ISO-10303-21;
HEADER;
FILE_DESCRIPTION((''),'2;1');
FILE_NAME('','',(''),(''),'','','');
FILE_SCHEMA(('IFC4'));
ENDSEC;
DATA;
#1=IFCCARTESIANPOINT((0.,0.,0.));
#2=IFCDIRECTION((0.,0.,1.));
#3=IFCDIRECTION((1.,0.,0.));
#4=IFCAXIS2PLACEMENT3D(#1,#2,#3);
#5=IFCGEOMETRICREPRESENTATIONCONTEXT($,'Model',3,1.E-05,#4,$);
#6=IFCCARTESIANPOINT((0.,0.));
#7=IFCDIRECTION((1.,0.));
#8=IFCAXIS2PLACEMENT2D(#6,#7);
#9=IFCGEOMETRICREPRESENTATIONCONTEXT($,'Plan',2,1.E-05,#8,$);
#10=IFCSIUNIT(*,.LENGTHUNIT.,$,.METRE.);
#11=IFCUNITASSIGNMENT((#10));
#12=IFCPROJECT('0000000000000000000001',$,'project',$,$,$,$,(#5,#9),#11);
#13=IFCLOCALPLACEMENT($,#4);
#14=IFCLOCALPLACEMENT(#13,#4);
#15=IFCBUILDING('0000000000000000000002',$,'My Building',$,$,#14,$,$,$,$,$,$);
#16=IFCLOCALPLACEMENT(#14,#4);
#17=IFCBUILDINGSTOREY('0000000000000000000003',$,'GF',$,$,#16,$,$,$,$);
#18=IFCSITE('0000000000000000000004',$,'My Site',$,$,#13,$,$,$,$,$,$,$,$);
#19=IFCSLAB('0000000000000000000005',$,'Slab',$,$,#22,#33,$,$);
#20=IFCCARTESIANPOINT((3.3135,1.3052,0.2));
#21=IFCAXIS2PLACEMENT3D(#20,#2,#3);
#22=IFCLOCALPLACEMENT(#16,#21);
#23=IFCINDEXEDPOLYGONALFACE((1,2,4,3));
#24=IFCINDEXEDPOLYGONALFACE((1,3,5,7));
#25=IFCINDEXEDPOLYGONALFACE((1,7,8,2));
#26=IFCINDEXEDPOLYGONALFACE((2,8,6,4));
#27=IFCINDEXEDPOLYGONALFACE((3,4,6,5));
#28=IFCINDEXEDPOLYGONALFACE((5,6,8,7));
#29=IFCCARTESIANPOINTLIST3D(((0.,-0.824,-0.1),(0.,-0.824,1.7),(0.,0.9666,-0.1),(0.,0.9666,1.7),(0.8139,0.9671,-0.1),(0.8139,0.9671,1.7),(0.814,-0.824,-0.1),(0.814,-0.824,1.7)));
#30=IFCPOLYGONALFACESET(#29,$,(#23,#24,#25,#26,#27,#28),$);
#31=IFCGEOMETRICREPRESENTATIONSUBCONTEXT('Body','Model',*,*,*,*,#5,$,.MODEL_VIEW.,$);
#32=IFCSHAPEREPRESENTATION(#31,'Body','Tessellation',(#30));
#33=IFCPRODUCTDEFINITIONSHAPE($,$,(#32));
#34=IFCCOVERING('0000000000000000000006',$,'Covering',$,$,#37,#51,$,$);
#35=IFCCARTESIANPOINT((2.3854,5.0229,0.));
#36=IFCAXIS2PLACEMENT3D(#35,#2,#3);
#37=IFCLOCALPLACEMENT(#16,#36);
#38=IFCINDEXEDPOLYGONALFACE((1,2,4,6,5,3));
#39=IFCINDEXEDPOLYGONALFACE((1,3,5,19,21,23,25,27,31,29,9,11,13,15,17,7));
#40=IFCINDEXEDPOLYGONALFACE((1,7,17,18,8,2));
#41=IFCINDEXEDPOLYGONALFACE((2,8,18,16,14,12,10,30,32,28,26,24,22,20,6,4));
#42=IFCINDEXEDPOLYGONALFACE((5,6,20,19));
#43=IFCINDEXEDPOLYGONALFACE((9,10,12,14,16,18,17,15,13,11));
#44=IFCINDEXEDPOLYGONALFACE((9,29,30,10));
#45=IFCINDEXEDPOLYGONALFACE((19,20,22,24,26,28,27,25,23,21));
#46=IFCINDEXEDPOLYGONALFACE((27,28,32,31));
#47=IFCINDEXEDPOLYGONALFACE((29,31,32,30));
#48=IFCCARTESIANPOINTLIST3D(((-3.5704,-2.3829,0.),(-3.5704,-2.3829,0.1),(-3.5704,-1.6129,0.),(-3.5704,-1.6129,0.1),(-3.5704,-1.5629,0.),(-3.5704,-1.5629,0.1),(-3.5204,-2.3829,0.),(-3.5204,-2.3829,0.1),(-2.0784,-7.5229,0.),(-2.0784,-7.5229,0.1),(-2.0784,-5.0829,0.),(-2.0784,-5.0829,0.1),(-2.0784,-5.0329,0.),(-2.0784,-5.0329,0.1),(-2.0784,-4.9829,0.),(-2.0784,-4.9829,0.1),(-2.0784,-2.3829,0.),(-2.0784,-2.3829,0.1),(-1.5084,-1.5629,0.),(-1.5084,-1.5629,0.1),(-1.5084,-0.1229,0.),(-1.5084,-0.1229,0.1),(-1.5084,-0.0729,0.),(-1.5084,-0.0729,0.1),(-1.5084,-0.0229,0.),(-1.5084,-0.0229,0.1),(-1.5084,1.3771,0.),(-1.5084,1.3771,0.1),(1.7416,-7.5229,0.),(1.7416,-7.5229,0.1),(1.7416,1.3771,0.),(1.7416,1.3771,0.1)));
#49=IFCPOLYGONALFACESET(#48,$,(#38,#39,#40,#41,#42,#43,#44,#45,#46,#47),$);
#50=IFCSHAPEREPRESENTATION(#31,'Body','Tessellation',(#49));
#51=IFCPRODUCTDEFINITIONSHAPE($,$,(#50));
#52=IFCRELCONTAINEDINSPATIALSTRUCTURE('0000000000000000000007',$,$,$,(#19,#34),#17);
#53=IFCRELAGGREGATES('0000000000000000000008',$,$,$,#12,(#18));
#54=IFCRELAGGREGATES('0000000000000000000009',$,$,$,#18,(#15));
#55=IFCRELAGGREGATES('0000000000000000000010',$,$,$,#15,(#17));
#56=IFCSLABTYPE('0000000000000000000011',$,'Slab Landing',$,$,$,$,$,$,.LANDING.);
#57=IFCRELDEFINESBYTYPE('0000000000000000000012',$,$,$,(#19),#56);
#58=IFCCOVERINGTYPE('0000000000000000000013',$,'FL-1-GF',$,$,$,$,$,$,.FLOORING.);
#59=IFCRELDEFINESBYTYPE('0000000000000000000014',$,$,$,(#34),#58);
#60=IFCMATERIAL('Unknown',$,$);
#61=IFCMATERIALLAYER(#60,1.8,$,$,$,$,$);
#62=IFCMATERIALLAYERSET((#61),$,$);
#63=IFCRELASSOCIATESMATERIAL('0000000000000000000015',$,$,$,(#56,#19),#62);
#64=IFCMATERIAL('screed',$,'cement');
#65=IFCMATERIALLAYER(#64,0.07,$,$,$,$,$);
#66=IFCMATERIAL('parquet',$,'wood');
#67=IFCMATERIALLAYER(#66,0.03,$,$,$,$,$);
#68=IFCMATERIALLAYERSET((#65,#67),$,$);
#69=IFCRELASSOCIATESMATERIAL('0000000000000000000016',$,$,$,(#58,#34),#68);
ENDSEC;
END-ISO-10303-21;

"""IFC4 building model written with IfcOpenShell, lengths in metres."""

from ifc_helpers import new_model, si_unit, frame, origin_with_axes, origin_2d_with_axis, place, context, subcontext, project, spatial, line, indexed_curve, outline, extrude, material, layer, layer_set, layer_usage, type_object, element, save


model = new_model("IFC4")

# Units and contexts
model_context = context("Model", 3, precision=1e-05, world=origin_with_axes())
plan_context = context("Plan", 2, precision=1e-05, world=origin_2d_with_axis())
body_context_1 = subcontext(model_context, "Body", "Model", "MODEL_VIEW")
ifc_project = project(units=[si_unit("LENGTHUNIT", "METRE")], contexts=[model_context, plan_context])

# Site, building, storey
site_placement = place(None, origin_with_axes())
site = spatial("IfcSite", under=ifc_project, at=site_placement, Name="My Site")
building_placement = place(site_placement, origin_with_axes())
building = spatial("IfcBuilding", under=site, at=building_placement, Name="My Building")
storey_placement = place(building_placement, origin_with_axes())
storey = spatial("IfcBuildingStorey", under=building, at=storey_placement, Name="GF")

# Slab
ifc_material_1 = material(Name="Unknown")
ifc_layer_1 = layer(ifc_material_1, 1.8)
ifc_layer_set_1 = layer_set([ifc_layer_1])
ifc_layer_usage_1 = layer_usage(ifc_layer_set_1, "AXIS3", "POSITIVE", -0.1)
slab_type_1 = type_object("IfcSlabType", Name="Slab Landing", PredefinedType="LANDING", material=ifc_layer_set_1)
slab_1_placement = place(storey_placement, frame((3.3135, 1.3052, 0.2), z_axis=(0.0, 0.0, 1.0), x_axis=(1.0, 0.0, 0.0)))
element("IfcSlab", 1, at=slab_1_placement, inside=storey, type_object=slab_type_1, material=ifc_layer_usage_1, Name="Slab", context=body_context_1, shape_type="SweptSolid", body=[
    extrude(outline(indexed_curve([(0.0, 0.9666), (0.0, -0.824), (0.814, -0.824), (0.8139, 0.9671), (0.0, 0.9666)])), frame((0.0, 0.0, -0.1), z_axis=(0.0, 0.0, 1.0), x_axis=(1.0, 0.0, 0.0)), (0.0, 0.0, 1.0), 1.8),
])

# Covering
ifc_material_2 = material(Name="screed", Category="cement")
ifc_layer_2 = layer(ifc_material_2, 0.07)
ifc_material_3 = material(Name="parquet", Category="wood")
ifc_layer_3 = layer(ifc_material_3, 0.03)
ifc_layer_set_2 = layer_set([ifc_layer_2, ifc_layer_3])
ifc_layer_usage_2 = layer_usage(ifc_layer_set_2, "AXIS3", "POSITIVE", 0.0)
covering_type = type_object("IfcCoveringType", Name="FL-1-GF", PredefinedType="FLOORING", material=ifc_layer_set_2)
covering_placement = place(storey_placement, frame((2.3854, 5.0229, 0.0), z_axis=(0.0, 0.0, 1.0), x_axis=(1.0, 0.0, 0.0)))
element("IfcCovering", 2, at=covering_placement, inside=storey, type_object=covering_type, material=ifc_layer_usage_2, Name="Covering", context=body_context_1, shape_type="SweptSolid", body=[
    extrude(outline(indexed_curve([(-1.5084, 1.3771), (1.7416, 1.3771), (1.7416, -7.5229), (-2.0784, -7.5229), (-2.0784, -7.5229), (-2.0784, -5.0829), (-2.0784, -5.0329), (-2.0784, -5.0329), (-2.0784, -4.9829), (-2.0784, -2.3829), (-3.5204, -2.3829), (-3.5704, -2.3829), (-3.5704, -1.6129), (-3.5704, -1.5629), (-1.5084, -1.5629), (-1.5084, -0.1229), (-1.5084, -0.0729), (-1.5084, -0.0229)], segments=[line(1, 2, 3, 4, 5, 6, 7, 8, 9, 10, 11, 12, 13, 14, 15, 16, 17, 18, 1)])), origin_with_axes(), (0.0, 0.0, 1.0), 0.1),
])

save(model, "model.ifc")
